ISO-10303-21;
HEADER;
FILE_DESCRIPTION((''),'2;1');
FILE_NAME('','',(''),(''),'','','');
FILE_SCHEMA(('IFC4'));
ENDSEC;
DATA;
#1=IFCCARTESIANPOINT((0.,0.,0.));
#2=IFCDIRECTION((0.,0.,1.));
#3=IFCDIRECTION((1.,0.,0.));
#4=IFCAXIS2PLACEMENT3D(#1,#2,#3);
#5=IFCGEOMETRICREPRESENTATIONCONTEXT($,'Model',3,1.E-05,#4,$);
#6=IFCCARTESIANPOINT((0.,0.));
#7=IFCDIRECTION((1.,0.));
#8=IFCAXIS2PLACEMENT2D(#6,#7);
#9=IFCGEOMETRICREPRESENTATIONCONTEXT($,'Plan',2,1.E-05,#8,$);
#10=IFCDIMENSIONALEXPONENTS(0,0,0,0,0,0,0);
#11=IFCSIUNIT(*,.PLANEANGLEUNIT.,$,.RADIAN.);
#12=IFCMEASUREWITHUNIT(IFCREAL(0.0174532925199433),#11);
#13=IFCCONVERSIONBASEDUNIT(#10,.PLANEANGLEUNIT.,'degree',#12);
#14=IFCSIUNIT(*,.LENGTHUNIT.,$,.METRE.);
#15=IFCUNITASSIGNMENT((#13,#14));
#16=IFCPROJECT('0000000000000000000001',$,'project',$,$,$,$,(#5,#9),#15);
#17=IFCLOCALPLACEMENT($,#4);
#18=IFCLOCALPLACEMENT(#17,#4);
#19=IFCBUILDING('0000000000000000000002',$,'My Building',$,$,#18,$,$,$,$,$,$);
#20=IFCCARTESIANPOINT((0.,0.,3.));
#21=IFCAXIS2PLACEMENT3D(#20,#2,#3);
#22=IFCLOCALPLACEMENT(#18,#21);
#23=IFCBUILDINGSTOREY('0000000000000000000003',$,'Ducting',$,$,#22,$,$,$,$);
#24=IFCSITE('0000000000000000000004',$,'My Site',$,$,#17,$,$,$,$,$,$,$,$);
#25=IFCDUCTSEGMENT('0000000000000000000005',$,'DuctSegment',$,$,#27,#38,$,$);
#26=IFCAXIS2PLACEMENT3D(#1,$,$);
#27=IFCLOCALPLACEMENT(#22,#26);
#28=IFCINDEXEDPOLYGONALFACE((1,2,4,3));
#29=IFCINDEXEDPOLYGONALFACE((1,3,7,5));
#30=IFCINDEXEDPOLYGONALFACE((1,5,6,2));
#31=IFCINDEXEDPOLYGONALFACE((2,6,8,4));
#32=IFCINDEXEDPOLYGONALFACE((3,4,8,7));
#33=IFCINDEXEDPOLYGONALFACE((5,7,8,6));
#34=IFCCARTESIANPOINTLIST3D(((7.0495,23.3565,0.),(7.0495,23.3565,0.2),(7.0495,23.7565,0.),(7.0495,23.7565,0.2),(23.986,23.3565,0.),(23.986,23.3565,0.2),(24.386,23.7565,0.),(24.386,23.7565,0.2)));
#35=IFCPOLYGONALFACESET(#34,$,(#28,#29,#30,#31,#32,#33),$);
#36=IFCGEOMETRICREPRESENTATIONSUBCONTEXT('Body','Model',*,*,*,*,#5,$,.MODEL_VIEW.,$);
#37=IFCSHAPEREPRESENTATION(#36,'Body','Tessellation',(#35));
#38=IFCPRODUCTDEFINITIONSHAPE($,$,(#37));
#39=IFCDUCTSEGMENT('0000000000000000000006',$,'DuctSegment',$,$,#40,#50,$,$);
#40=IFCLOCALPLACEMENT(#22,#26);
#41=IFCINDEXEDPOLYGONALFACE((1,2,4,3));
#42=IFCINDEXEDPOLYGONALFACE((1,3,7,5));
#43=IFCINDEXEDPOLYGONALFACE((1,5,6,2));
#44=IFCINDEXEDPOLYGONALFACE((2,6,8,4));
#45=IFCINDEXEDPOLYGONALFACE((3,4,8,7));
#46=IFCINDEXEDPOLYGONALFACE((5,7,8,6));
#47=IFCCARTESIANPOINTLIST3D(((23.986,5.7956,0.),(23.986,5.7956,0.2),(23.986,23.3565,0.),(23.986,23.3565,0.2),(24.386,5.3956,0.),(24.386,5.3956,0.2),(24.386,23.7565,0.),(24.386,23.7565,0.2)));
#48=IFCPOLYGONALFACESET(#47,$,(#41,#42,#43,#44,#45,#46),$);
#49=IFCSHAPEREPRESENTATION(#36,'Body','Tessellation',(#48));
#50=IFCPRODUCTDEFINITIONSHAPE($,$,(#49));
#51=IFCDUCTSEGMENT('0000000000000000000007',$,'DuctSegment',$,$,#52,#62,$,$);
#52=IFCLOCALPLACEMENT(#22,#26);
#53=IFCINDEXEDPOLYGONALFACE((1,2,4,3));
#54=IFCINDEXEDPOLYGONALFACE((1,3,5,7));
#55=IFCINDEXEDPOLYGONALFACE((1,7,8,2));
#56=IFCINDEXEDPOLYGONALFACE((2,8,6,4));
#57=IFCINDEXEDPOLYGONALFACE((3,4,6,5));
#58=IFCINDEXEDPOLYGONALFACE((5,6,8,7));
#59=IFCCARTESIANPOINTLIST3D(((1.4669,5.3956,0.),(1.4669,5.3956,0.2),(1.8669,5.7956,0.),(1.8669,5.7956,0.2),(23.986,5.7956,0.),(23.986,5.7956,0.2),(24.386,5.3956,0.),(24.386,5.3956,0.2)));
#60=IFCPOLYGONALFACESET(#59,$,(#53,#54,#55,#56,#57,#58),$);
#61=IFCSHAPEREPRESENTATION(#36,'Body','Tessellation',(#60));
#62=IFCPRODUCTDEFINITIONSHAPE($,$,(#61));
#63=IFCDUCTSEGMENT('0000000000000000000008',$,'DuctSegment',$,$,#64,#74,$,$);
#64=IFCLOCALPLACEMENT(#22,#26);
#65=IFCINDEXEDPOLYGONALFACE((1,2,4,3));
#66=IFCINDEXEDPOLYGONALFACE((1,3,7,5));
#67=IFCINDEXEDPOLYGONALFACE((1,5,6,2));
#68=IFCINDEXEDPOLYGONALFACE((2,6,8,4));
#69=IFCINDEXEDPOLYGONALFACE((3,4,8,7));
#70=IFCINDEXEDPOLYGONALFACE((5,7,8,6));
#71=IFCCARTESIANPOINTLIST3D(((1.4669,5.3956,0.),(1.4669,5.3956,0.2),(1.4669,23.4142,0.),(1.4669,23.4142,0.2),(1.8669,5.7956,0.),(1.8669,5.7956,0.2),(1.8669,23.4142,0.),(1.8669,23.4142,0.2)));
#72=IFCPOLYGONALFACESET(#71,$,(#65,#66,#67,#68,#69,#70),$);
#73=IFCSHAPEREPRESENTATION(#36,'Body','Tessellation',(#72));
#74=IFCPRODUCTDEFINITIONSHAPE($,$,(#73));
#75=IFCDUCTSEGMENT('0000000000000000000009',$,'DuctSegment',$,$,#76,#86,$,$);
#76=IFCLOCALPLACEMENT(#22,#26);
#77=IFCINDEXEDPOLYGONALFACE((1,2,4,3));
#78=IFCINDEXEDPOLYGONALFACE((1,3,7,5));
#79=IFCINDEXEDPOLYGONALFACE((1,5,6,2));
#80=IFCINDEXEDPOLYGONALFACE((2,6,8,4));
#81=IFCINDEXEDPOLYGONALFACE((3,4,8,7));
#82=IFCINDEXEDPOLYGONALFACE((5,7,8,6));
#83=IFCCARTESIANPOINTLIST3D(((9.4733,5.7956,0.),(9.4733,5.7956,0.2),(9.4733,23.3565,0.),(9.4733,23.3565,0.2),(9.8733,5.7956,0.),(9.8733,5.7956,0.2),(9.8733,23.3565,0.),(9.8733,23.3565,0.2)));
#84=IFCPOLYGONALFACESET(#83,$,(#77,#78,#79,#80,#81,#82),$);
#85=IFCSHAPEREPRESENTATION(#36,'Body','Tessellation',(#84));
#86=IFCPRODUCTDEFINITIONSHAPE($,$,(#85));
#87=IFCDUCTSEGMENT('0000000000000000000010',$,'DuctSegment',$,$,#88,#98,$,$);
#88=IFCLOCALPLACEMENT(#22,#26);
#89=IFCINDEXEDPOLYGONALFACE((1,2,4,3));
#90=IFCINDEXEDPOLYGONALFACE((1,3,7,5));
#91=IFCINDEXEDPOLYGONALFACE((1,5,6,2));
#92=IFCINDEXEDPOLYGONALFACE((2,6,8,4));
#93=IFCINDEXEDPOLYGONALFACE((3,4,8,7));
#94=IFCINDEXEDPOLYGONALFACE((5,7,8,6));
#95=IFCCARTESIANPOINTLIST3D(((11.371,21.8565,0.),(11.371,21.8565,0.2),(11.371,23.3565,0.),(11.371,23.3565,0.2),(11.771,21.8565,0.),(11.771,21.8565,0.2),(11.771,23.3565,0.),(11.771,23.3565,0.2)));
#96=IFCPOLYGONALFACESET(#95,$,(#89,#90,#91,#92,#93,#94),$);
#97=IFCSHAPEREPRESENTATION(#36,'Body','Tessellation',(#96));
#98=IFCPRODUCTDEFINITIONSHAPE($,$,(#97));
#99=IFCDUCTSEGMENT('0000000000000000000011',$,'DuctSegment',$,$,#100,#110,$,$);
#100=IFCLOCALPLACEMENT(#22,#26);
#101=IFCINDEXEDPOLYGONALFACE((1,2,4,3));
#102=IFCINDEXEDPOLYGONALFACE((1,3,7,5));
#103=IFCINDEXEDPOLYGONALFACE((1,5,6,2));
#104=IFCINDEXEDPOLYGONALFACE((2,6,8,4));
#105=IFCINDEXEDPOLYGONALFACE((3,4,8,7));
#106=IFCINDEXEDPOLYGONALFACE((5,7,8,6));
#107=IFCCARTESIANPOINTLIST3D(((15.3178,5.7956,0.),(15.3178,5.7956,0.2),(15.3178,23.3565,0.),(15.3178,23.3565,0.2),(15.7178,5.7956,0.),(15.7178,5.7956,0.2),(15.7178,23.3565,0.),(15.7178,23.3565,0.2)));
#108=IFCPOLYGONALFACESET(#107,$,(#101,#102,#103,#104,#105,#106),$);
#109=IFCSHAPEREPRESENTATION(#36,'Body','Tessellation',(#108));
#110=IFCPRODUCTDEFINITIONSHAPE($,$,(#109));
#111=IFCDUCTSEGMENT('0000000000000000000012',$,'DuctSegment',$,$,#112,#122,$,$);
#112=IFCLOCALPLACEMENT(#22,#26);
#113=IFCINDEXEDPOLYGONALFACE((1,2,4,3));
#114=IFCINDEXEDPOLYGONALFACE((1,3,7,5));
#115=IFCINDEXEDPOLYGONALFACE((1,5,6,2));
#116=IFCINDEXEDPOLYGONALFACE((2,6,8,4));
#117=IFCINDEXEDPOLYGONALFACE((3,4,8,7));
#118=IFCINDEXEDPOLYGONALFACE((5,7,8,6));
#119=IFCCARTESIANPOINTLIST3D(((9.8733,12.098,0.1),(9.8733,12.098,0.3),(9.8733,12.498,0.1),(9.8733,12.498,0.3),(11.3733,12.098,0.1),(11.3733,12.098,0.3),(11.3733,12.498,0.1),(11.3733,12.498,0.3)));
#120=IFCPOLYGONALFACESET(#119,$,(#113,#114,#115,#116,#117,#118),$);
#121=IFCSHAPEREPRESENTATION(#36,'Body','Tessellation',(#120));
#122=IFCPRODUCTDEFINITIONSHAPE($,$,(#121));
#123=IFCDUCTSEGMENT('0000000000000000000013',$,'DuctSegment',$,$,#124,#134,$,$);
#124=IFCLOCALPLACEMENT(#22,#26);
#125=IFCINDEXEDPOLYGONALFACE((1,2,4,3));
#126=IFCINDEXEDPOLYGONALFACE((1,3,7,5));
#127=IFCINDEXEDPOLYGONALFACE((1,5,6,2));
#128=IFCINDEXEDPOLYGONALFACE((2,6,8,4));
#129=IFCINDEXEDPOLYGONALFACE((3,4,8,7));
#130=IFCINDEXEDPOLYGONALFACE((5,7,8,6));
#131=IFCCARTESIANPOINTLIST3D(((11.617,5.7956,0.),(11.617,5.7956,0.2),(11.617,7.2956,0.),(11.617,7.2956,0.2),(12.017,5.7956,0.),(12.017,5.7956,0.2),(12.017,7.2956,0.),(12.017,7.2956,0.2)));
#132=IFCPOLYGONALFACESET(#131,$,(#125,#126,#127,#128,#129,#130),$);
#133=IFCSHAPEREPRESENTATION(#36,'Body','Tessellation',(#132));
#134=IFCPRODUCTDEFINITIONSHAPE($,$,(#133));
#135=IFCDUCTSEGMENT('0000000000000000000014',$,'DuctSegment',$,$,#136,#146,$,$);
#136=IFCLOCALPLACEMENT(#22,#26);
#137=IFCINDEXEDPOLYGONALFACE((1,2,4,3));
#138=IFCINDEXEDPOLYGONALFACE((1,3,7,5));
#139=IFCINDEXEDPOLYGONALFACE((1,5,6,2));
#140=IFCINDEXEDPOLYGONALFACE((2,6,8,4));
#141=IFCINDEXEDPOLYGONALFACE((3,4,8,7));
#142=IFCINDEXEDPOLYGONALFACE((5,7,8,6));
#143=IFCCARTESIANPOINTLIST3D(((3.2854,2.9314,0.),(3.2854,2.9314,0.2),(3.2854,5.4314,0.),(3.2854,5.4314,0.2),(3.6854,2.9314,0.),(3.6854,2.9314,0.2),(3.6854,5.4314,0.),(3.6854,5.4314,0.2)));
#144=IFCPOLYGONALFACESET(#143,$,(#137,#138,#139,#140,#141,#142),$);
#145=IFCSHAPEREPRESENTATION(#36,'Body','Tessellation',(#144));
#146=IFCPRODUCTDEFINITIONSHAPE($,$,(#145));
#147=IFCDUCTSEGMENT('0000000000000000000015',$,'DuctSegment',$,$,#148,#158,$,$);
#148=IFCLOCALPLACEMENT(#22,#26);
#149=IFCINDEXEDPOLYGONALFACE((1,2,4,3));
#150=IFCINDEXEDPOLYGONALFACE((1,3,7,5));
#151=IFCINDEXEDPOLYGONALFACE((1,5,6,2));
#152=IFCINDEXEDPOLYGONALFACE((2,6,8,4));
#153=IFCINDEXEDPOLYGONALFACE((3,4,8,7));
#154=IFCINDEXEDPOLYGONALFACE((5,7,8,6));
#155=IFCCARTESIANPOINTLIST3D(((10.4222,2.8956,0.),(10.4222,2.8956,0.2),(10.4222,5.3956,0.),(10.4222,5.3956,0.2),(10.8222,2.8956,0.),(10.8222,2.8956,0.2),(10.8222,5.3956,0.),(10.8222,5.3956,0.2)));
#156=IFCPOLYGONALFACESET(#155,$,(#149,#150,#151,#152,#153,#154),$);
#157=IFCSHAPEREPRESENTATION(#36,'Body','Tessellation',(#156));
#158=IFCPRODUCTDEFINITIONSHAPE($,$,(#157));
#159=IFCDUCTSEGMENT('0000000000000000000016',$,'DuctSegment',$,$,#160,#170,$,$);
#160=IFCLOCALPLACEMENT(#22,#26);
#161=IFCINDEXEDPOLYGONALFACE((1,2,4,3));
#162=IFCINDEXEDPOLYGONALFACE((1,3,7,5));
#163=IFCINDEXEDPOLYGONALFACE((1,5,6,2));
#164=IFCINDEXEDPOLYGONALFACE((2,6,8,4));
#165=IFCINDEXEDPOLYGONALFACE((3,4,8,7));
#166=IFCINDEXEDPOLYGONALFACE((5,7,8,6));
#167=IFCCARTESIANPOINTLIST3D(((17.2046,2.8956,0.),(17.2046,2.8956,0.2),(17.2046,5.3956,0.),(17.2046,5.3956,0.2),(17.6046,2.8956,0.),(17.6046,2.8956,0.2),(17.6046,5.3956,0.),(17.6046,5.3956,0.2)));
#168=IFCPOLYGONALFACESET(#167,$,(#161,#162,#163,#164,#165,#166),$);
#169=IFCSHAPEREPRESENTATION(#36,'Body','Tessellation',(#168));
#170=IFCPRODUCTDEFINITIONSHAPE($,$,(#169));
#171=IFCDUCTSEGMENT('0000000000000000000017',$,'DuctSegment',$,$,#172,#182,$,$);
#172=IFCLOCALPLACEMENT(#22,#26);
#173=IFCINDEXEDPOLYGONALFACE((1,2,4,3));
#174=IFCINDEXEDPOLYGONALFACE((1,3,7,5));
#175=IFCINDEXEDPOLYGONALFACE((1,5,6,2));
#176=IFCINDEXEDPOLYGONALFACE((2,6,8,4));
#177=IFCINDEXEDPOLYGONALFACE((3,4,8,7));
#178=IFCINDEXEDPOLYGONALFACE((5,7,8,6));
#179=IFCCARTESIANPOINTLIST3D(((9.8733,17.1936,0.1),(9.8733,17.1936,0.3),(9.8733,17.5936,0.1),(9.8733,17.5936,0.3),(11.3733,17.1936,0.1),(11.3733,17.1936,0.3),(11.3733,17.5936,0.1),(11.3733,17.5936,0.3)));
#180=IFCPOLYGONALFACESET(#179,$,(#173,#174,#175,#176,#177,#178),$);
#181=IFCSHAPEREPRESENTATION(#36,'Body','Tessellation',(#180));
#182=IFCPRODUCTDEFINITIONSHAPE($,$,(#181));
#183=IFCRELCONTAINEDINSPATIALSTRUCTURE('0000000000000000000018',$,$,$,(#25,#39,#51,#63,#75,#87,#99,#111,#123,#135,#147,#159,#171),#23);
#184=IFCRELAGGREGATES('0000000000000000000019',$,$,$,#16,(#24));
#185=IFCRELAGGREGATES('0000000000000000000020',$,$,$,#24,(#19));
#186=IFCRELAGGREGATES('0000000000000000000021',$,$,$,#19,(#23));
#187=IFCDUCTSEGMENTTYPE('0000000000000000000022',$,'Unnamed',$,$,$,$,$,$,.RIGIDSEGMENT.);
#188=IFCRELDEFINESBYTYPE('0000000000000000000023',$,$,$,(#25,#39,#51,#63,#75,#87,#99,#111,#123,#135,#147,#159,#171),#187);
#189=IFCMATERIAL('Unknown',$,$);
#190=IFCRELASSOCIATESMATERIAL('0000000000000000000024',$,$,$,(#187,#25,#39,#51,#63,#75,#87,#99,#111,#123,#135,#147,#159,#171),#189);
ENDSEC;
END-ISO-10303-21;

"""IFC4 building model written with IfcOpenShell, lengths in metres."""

from ifc_helpers import new_model, entity, si_unit, converted_unit, frame, origin_with_axes, origin_2d_with_axis, place, context, subcontext, project, spatial, rectangle, extrude, clip, halfspace, material, material_profile, profile_set, profile_usage, type_object, element, save


model = new_model("IFC4")

# Units and contexts
model_context = context("Model", 3, precision=1e-05, world=origin_with_axes())
plan_context = context("Plan", 2, precision=1e-05, world=origin_2d_with_axis())
body_context = subcontext(model_context, "Body", "Model", "MODEL_VIEW")
ifc_project = project(units=[converted_unit("PLANEANGLEUNIT", "degree", entity("IfcReal", 0.0174532925199433), si_unit("PLANEANGLEUNIT", "RADIAN"), dimensions=[0, 0, 0, 0, 0, 0, 0]), si_unit("LENGTHUNIT", "METRE")], contexts=[model_context, plan_context])

# Site, building, storey
site_placement = place(None, origin_with_axes())
site = spatial("IfcSite", under=ifc_project, at=site_placement, Name="My Site")
building_placement = place(site_placement, origin_with_axes())
building = spatial("IfcBuilding", under=site, at=building_placement, Name="My Building")
storey_placement = place(building_placement, frame((0.0, 0.0, 3.0), z_axis=(0.0, 0.0, 1.0), x_axis=(1.0, 0.0, 0.0)))
storey = spatial("IfcBuildingStorey", under=building, at=storey_placement, Name="Ducting")

# Duct segments
ifc_material = material(Name="Unknown")
ifc_material_profile = material_profile(ifc_material, rectangle(XDim=0.4, YDim=0.2))
ifc_profile_set = profile_set([ifc_material_profile])
ifc_profile_usage_1 = profile_usage(ifc_profile_set, cardinal=5)
duct_segment_type = type_object("IfcDuctSegmentType", Name="Unnamed", PredefinedType="RIGIDSEGMENT", material=ifc_profile_set)
duct_segment_1_placement = place(storey_placement, frame((7.0495, 23.5565, 0.1), z_axis=(1.0, 0.0, 0.0), x_axis=(0.0, 1.0, 0.0)))
element("IfcDuctSegment", 1, at=duct_segment_1_placement, inside=storey, type_object=duct_segment_type, material=ifc_profile_usage_1, Name="DuctSegment", context=body_context, shape_type="Clipping", body=[
    clip(extrude(rectangle(XDim=0.4, YDim=0.2), origin_with_axes(), (0.0, 0.0, 1.0), 17.3366), halfspace(frame((0.2, -3.0, 17.3366), z_axis=(-0.707108, 0.0, 0.707105), x_axis=(0.0, 1.0, 0.0)), False)),
])
ifc_profile_usage_2 = profile_usage(ifc_profile_set, cardinal=5)
duct_segment_2_placement = place(storey_placement, frame((24.186, 23.7565, 0.1), z_axis=(0.0, -1.0, 0.0), x_axis=(1.0, 0.0, 0.0)))
element("IfcDuctSegment", 2, at=duct_segment_2_placement, inside=storey, type_object=duct_segment_type, material=ifc_profile_usage_2, Name="DuctSegment", context=body_context, shape_type="Clipping", body=[
    clip(clip(extrude(rectangle(XDim=0.4, YDim=0.2), origin_with_axes(), (0.0, 0.0, 1.0), 18.3609), halfspace(frame((0.2, -3.0, 18.3609), z_axis=(-0.707103, 0.0, 0.70711), x_axis=(0.0, 1.0, 0.0)), False)), halfspace(frame((0.2, -3.0, 0.0), z_axis=(-0.707105, 0.0, -0.707108), x_axis=(0.0, 1.0, 0.0)), False)),
])
ifc_profile_usage_3 = profile_usage(ifc_profile_set, cardinal=5)
duct_segment_3_placement = place(storey_placement, frame((24.386, 5.5956, 0.1), z_axis=(-1.0, 0.0, 0.0), x_axis=(0.0, -1.0, 0.0)))
element("IfcDuctSegment", 3, at=duct_segment_3_placement, inside=storey, type_object=duct_segment_type, material=ifc_profile_usage_3, Name="DuctSegment", context=body_context, shape_type="Clipping", body=[
    clip(clip(extrude(rectangle(XDim=0.4, YDim=0.2), origin_with_axes(), (0.0, 0.0, 1.0), 22.9192), halfspace(frame((0.2, -3.0, 22.9192), z_axis=(-0.707107, 0.0, 0.707106), x_axis=(-0.000001, 1.0, 0.0)), False)), halfspace(frame((0.2, -3.0, 0.0), z_axis=(-0.70711, 0.0, -0.707104), x_axis=(0.0, 1.0, 0.0)), False)),
])
ifc_profile_usage_4 = profile_usage(ifc_profile_set, cardinal=5)
duct_segment_4_placement = place(storey_placement, frame((1.6669, 5.3956, 0.1), z_axis=(0.0, 1.0, 0.0), x_axis=(-1.0, 0.0, 0.0)))
element("IfcDuctSegment", 4, at=duct_segment_4_placement, inside=storey, type_object=duct_segment_type, material=ifc_profile_usage_4, Name="DuctSegment", context=body_context, shape_type="Clipping", body=[
    clip(extrude(rectangle(XDim=0.4, YDim=0.2), origin_with_axes(), (0.0, 0.0, 1.0), 18.0186), halfspace(frame((0.2, -3.0, 0.0), z_axis=(-0.707107, 0.0, -0.707107), x_axis=(0.0, 1.0, 0.0)), False)),
])
ifc_profile_usage_5 = profile_usage(ifc_profile_set, cardinal=5)
duct_segment_5_placement = place(storey_placement, frame((9.6733, 23.3565, 0.1), z_axis=(0.0, -1.0, 0.0), x_axis=(1.0, 0.0, 0.0)))
element("IfcDuctSegment", 5, at=duct_segment_5_placement, inside=storey, type_object=duct_segment_type, material=ifc_profile_usage_5, Name="DuctSegment", context=body_context, shape_type="SweptSolid", body=[
    extrude(rectangle(XDim=0.4, YDim=0.2), origin_with_axes(), (0.0, 0.0, 1.0), 17.5609),
])
ifc_profile_usage_6 = profile_usage(ifc_profile_set, cardinal=5)
duct_segment_6_placement = place(storey_placement, frame((11.571, 23.3565, 0.1), z_axis=(0.0, -1.0, 0.0), x_axis=(1.0, 0.0, 0.0)))
element("IfcDuctSegment", 6, at=duct_segment_6_placement, inside=storey, type_object=duct_segment_type, material=ifc_profile_usage_6, Name="DuctSegment", context=body_context, shape_type="SweptSolid", body=[
    extrude(rectangle(XDim=0.4, YDim=0.2), origin_with_axes(), (0.0, 0.0, 1.0), 1.5),
])
ifc_profile_usage_7 = profile_usage(ifc_profile_set, cardinal=5)
duct_segment_7_placement = place(storey_placement, frame((15.5178, 23.3565, 0.1), z_axis=(0.0, -1.0, 0.0), x_axis=(1.0, 0.0, 0.0)))
element("IfcDuctSegment", 7, at=duct_segment_7_placement, inside=storey, type_object=duct_segment_type, material=ifc_profile_usage_7, Name="DuctSegment", context=body_context, shape_type="SweptSolid", body=[
    extrude(rectangle(XDim=0.4, YDim=0.2), origin_with_axes(), (0.0, 0.0, 1.0), 17.5609),
])
ifc_profile_usage_8 = profile_usage(ifc_profile_set, cardinal=5)
duct_segment_8_placement = place(storey_placement, frame((9.8733, 12.298, 0.2), z_axis=(1.0, 0.0, 0.0), x_axis=(0.0, 1.0, 0.0)))
element("IfcDuctSegment", 8, at=duct_segment_8_placement, inside=storey, type_object=duct_segment_type, material=ifc_profile_usage_8, Name="DuctSegment", context=body_context, shape_type="SweptSolid", body=[
    extrude(rectangle(XDim=0.4, YDim=0.2), origin_with_axes(), (0.0, 0.0, 1.0), 1.5),
])
ifc_profile_usage_9 = profile_usage(ifc_profile_set, cardinal=5)
duct_segment_9_placement = place(storey_placement, frame((11.817, 5.7956, 0.1), z_axis=(0.0, 1.0, 0.0), x_axis=(-1.0, 0.0, 0.0)))
element("IfcDuctSegment", 9, at=duct_segment_9_placement, inside=storey, type_object=duct_segment_type, material=ifc_profile_usage_9, Name="DuctSegment", context=body_context, shape_type="SweptSolid", body=[
    extrude(rectangle(XDim=0.4, YDim=0.2), origin_with_axes(), (0.0, 0.0, 1.0), 1.5),
])
ifc_profile_usage_10 = profile_usage(ifc_profile_set, cardinal=5)
duct_segment_10_placement = place(storey_placement, frame((3.4854, 5.4314, 0.1), z_axis=(0.0, -1.0, 0.0), x_axis=(1.0, 0.0, 0.0)))
element("IfcDuctSegment", 10, at=duct_segment_10_placement, inside=storey, type_object=duct_segment_type, material=ifc_profile_usage_10, Name="DuctSegment", context=body_context, shape_type="SweptSolid", body=[
    extrude(rectangle(XDim=0.4, YDim=0.2), origin_with_axes(), (0.0, 0.0, 1.0), 2.5),
])
ifc_profile_usage_11 = profile_usage(ifc_profile_set, cardinal=5)
duct_segment_11_placement = place(storey_placement, frame((10.6222, 5.3956, 0.1), z_axis=(0.0, -1.0, 0.0), x_axis=(1.0, 0.0, 0.0)))
element("IfcDuctSegment", 11, at=duct_segment_11_placement, inside=storey, type_object=duct_segment_type, material=ifc_profile_usage_11, Name="DuctSegment", context=body_context, shape_type="SweptSolid", body=[
    extrude(rectangle(XDim=0.4, YDim=0.2), origin_with_axes(), (0.0, 0.0, 1.0), 2.5),
])
ifc_profile_usage_12 = profile_usage(ifc_profile_set, cardinal=5)
duct_segment_12_placement = place(storey_placement, frame((17.4046, 5.3956, 0.1), z_axis=(0.0, -1.0, 0.0), x_axis=(1.0, 0.0, 0.0)))
element("IfcDuctSegment", 12, at=duct_segment_12_placement, inside=storey, type_object=duct_segment_type, material=ifc_profile_usage_12, Name="DuctSegment", context=body_context, shape_type="SweptSolid", body=[
    extrude(rectangle(XDim=0.4, YDim=0.2), origin_with_axes(), (0.0, 0.0, 1.0), 2.5),
])
ifc_profile_usage_13 = profile_usage(ifc_profile_set, cardinal=5)
duct_segment_13_placement = place(storey_placement, frame((9.8733, 17.3936, 0.2), z_axis=(1.0, 0.0, 0.0), x_axis=(0.0, 1.0, 0.0)))
element("IfcDuctSegment", 13, at=duct_segment_13_placement, inside=storey, type_object=duct_segment_type, material=ifc_profile_usage_13, Name="DuctSegment", context=body_context, shape_type="SweptSolid", body=[
    extrude(rectangle(XDim=0.4, YDim=0.2), origin_with_axes(), (0.0, 0.0, 1.0), 1.5),
])

save(model, "model.ifc")
